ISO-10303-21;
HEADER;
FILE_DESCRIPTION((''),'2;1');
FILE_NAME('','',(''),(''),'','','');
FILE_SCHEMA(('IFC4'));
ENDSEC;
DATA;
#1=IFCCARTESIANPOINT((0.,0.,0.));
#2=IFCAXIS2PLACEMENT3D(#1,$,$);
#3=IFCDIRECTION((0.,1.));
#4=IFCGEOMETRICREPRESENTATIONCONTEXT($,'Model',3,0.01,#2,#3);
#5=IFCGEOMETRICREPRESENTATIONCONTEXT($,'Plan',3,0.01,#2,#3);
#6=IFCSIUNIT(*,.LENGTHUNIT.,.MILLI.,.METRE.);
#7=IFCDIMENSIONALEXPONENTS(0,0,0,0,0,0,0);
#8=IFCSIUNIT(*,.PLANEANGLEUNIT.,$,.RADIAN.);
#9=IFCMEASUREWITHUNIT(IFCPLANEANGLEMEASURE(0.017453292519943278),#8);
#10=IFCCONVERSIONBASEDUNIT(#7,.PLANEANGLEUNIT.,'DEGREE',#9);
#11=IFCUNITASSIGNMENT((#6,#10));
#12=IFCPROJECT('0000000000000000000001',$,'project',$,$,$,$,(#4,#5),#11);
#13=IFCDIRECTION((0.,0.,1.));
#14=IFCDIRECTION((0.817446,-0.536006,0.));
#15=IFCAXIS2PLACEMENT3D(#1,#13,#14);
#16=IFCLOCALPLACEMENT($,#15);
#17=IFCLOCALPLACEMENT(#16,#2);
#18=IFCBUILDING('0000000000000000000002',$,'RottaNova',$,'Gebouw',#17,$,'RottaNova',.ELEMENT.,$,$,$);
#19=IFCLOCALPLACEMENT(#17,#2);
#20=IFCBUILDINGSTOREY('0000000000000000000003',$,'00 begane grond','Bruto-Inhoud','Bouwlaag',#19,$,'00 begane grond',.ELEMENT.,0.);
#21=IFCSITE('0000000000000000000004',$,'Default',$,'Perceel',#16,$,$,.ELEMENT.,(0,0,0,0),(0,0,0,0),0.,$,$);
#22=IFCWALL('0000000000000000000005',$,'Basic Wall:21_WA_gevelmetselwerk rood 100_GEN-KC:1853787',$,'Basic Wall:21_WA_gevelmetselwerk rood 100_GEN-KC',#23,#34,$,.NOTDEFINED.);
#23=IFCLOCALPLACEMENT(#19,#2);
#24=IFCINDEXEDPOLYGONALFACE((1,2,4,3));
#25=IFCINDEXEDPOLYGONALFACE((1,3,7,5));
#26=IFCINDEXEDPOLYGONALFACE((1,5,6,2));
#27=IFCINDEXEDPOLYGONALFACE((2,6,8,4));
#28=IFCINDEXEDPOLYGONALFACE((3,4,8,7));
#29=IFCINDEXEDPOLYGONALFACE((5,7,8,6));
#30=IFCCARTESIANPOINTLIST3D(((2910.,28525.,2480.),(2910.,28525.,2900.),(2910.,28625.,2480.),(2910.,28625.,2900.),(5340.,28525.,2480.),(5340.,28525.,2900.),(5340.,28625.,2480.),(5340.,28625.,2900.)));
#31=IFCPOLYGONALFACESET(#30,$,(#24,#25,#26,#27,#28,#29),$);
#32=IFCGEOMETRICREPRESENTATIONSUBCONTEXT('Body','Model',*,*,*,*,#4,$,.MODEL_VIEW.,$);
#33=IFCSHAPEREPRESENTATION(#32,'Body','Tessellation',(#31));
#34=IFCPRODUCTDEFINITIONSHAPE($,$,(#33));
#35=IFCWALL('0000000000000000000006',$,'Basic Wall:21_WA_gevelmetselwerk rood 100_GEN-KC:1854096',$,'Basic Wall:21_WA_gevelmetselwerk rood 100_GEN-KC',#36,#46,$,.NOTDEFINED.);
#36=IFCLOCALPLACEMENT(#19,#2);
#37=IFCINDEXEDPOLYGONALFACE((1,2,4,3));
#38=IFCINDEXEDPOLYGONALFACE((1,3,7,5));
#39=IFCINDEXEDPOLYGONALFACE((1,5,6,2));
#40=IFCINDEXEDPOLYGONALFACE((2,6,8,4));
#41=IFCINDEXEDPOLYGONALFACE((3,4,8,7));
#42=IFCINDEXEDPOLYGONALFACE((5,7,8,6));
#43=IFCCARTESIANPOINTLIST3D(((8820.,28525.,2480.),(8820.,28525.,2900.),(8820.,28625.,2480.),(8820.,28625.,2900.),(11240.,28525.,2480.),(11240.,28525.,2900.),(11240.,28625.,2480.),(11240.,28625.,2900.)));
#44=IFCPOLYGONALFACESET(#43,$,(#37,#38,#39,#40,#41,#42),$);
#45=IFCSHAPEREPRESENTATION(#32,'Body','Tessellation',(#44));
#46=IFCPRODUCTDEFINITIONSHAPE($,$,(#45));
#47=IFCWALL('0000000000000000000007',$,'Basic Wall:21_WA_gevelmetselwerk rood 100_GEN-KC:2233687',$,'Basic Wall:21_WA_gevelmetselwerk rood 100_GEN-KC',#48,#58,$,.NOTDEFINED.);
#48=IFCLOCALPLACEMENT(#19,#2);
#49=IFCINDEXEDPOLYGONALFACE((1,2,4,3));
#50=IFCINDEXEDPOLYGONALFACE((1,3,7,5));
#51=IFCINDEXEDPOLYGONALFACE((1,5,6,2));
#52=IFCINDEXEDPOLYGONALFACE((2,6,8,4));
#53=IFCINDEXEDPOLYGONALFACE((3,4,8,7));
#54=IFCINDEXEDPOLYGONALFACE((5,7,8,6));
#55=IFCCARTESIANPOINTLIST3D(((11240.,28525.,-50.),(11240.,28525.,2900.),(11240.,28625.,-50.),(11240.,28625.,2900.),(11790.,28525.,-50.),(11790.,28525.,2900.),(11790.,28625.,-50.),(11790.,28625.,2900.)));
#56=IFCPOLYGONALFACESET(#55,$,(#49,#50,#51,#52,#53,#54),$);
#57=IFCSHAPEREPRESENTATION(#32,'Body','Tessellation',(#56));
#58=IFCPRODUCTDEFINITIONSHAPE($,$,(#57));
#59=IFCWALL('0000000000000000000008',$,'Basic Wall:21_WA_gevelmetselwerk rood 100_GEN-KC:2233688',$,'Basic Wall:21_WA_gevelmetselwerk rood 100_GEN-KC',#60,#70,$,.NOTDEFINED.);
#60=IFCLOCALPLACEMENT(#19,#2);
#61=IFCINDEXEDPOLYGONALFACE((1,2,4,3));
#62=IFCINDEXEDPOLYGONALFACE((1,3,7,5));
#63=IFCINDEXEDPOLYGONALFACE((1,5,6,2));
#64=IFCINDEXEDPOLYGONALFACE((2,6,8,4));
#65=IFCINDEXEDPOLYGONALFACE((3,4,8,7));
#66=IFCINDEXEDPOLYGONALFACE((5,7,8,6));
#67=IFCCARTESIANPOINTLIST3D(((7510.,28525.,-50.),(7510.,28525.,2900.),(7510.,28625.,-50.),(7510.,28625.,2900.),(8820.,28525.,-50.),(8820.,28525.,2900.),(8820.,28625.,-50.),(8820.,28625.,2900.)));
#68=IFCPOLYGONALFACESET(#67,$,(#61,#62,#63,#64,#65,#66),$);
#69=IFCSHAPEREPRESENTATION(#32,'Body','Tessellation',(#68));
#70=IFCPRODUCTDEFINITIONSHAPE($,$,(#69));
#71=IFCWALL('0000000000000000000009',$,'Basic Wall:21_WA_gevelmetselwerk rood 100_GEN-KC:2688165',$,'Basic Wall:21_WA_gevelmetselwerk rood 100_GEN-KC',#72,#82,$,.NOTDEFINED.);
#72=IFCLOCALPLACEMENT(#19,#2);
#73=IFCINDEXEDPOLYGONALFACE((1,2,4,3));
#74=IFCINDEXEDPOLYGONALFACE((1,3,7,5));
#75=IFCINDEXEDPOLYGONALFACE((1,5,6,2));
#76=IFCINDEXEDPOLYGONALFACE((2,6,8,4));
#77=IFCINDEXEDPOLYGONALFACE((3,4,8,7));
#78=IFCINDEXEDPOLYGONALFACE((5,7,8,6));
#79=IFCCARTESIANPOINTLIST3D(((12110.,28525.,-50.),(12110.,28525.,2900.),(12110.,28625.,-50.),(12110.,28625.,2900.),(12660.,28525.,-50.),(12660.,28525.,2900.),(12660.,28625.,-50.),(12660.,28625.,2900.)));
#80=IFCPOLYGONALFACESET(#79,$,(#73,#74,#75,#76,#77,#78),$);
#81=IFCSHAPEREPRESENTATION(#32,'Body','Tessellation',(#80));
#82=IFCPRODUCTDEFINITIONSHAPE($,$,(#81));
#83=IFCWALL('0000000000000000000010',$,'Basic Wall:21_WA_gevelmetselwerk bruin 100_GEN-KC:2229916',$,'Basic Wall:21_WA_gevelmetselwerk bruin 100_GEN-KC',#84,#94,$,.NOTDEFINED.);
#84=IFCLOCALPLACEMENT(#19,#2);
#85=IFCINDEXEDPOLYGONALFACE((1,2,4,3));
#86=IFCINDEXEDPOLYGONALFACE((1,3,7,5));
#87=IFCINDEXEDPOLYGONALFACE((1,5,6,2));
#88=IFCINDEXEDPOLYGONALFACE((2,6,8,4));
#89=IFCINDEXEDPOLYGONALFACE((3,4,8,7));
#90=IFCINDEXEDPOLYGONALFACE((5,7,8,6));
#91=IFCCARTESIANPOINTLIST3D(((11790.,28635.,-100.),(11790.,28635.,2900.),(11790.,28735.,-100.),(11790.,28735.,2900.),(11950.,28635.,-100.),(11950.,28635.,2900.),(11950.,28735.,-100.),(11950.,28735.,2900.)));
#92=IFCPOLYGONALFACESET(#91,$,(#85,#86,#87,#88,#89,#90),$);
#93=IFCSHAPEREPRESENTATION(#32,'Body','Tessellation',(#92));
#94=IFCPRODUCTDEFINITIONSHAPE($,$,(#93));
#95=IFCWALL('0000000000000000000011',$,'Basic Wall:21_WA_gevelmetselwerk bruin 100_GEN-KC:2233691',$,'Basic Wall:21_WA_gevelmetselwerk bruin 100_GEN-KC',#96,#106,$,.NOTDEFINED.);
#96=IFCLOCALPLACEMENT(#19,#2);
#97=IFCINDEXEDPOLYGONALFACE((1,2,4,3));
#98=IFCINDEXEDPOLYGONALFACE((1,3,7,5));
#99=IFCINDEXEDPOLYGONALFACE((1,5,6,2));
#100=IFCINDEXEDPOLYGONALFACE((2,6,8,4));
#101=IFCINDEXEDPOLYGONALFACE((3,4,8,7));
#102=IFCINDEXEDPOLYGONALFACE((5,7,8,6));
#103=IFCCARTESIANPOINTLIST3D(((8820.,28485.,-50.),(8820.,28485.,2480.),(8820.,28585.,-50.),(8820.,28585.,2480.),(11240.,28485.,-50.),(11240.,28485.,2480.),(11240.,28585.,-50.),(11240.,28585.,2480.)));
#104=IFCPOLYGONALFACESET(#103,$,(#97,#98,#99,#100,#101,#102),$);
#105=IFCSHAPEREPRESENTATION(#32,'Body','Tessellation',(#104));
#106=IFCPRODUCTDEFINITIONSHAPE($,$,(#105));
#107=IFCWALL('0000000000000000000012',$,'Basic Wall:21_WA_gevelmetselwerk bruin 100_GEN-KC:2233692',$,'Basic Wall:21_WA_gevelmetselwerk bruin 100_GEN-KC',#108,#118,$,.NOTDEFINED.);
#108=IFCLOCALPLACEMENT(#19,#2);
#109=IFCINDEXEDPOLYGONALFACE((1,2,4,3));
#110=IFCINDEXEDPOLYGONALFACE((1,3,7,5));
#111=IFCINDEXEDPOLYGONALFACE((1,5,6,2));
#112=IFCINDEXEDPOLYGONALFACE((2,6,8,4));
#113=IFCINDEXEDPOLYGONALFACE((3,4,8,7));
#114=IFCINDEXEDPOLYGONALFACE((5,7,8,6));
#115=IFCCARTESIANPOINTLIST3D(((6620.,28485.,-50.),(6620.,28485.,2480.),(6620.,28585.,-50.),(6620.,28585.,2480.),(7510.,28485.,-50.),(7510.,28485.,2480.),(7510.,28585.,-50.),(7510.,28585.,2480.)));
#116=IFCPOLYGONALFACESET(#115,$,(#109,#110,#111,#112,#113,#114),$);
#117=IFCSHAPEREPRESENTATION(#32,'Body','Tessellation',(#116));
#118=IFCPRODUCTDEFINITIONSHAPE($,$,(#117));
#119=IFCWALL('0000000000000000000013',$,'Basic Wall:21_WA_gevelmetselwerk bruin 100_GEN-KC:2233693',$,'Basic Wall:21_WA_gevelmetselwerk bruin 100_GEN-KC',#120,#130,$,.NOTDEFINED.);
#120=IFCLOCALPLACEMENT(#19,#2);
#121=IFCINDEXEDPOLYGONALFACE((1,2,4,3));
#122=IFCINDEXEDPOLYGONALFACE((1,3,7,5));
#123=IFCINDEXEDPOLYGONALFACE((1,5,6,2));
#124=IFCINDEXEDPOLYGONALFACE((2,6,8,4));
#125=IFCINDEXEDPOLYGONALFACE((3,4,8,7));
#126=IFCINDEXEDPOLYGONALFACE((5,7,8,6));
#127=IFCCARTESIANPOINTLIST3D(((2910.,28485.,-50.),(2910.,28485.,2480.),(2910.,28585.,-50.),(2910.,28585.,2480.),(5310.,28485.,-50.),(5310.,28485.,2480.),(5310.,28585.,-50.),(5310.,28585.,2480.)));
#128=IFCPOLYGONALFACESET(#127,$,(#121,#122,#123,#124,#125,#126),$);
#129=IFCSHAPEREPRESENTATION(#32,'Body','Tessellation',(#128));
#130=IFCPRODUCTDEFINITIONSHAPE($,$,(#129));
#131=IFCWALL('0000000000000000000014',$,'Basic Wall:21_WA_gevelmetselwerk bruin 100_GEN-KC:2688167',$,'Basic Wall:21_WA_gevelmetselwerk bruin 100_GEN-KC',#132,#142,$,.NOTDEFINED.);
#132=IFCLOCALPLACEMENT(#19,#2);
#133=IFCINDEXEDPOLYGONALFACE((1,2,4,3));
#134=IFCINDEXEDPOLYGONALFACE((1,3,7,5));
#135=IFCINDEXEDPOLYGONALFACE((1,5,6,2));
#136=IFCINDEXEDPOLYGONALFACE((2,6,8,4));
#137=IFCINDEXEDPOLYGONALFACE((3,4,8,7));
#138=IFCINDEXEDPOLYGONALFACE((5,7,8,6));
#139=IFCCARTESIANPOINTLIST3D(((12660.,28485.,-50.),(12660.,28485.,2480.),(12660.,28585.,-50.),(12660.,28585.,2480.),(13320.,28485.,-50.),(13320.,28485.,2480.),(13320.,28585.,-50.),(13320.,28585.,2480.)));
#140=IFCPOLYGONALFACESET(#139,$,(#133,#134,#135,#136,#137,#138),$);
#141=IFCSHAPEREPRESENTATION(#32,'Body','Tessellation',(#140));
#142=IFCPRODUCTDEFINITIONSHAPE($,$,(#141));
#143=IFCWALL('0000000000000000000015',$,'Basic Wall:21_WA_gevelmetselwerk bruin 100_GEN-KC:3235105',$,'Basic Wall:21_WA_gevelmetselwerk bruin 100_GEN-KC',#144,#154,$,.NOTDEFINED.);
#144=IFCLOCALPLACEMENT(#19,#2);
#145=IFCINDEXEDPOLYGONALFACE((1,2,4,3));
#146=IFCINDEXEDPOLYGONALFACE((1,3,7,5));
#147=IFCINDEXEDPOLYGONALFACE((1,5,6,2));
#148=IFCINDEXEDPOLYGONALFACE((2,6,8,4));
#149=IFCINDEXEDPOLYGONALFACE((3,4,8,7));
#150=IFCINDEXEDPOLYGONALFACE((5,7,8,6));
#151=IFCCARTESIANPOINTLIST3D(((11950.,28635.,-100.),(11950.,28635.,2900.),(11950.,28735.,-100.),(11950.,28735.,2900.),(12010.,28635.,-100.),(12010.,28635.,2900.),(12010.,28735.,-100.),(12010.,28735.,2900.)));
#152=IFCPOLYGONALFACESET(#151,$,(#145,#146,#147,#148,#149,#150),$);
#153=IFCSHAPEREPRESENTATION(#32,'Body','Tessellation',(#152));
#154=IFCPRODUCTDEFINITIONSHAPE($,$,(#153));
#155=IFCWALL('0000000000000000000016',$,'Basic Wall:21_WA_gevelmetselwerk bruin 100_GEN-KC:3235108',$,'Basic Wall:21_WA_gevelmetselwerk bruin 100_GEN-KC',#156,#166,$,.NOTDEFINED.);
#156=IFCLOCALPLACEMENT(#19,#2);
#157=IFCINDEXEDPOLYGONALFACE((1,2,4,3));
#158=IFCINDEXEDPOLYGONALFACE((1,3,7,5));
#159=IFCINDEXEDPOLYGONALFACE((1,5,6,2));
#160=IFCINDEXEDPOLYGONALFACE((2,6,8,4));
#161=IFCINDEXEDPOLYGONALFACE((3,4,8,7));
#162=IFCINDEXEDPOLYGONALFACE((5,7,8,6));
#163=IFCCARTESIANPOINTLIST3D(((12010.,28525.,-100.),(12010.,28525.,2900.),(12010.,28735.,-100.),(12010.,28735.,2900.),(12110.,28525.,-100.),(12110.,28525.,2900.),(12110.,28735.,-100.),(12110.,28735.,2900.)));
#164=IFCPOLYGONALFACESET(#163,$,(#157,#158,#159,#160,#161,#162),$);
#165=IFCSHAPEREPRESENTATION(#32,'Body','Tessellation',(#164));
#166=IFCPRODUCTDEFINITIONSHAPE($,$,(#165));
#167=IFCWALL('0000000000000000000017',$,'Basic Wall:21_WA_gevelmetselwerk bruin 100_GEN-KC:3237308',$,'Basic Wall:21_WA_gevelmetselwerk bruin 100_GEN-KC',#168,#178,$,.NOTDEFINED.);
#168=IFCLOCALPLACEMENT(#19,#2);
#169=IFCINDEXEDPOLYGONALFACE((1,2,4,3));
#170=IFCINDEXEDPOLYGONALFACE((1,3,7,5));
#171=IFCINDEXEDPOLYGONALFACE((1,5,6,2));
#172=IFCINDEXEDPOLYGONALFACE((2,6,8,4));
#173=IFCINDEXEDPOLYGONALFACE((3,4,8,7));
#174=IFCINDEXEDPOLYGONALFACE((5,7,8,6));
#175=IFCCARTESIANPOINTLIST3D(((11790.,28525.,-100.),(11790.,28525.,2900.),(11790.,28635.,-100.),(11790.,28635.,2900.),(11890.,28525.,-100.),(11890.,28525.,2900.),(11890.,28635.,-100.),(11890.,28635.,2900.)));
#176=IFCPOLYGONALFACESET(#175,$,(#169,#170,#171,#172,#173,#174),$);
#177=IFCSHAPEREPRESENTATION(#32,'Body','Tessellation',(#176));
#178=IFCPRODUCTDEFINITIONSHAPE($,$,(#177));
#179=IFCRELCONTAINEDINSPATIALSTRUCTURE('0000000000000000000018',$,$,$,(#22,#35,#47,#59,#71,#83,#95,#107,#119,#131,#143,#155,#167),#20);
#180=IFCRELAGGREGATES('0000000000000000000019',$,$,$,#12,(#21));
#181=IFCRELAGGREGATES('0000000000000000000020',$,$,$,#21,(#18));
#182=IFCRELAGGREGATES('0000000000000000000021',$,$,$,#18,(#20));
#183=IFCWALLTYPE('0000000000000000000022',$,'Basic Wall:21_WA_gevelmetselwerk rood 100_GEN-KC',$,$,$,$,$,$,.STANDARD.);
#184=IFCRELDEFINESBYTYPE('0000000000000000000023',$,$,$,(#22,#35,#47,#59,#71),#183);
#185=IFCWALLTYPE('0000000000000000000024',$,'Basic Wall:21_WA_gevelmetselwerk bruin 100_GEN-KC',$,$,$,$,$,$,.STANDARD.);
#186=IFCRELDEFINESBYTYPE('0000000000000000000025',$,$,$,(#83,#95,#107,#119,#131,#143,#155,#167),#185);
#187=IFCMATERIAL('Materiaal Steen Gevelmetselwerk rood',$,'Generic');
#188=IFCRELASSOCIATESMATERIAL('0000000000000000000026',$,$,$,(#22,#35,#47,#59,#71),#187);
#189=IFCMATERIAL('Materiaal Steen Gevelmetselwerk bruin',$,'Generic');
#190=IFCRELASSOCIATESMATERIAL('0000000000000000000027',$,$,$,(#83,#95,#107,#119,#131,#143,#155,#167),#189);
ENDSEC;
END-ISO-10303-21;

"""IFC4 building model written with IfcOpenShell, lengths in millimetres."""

from ifc_helpers import new_model, entity, si_unit, converted_unit, direction, frame, origin, place, context, subcontext, project, spatial, indexed_curve, outline, extrude, material, type_object, element, save


model = new_model("IFC4")

# Units and contexts
model_context = context("Model", 3, precision=0.01, world=origin(), true_north=direction((0.0, 1.0)))
plan_context = context("Plan", 3, precision=0.01, world=origin(), true_north=direction((0.0, 1.0)))
body_context = subcontext(model_context, "Body", "Model", "MODEL_VIEW")
ifc_project = project(units=[si_unit("LENGTHUNIT", "METRE", prefix="MILLI"), converted_unit("PLANEANGLEUNIT", "DEGREE", entity("IfcPlaneAngleMeasure", 0.017453292519943278), si_unit("PLANEANGLEUNIT", "RADIAN"), dimensions=[0, 0, 0, 0, 0, 0, 0])], contexts=[model_context, plan_context])

# Site, building, storey
site_placement = place(None, frame((0.0, 0.0, 0.0), z_axis=(0.0, 0.0, 1.0), x_axis=(0.817446, -0.536006, 0.0)))
site = spatial("IfcSite", under=ifc_project, at=site_placement, Name="Default", ObjectType="Perceel", CompositionType="ELEMENT", RefLatitude=(0, 0, 0, 0), RefLongitude=(0, 0, 0, 0), RefElevation=0.0)
building_placement = place(site_placement, origin())
building = spatial("IfcBuilding", under=site, at=building_placement, Name="RottaNova", ObjectType="Gebouw", LongName="RottaNova", CompositionType="ELEMENT")
storey_placement = place(building_placement, origin())
storey = spatial("IfcBuildingStorey", under=building, at=storey_placement, Name="00 begane grond", Description="Bruto-Inhoud", ObjectType="Bouwlaag", LongName="00 begane grond", CompositionType="ELEMENT", Elevation=0.0)

# Walls
ifc_material_1 = material(Name="Materiaal Steen Gevelmetselwerk rood", Category="Generic")
wall_type_1 = type_object("IfcWallType", Name="Basic Wall:21_WA_gevelmetselwerk rood 100_GEN-KC", PredefinedType="STANDARD")
wall_1_placement = place(storey_placement, frame((2910.0, 28575.0, 2480.0)))
element("IfcWall", 1, at=wall_1_placement, inside=storey, type_object=wall_type_1, material=ifc_material_1, Name="Basic Wall:21_WA_gevelmetselwerk rood 100_GEN-KC:1853787", ObjectType="Basic Wall:21_WA_gevelmetselwerk rood 100_GEN-KC", PredefinedType="NOTDEFINED", context=body_context, shape_type="SweptSolid", body=[
    extrude(outline(indexed_curve([(2430.0, 50.0), (0.0, 50.0), (0.0, -50.0), (2430.0, -50.0), (2430.0, 50.0)], self_intersect=False)), origin(), (0.0, 0.0, 1.0), 420.0),
])
wall_2_placement = place(storey_placement, frame((8820.0, 28575.0, 2480.0)))
element("IfcWall", 2, at=wall_2_placement, inside=storey, type_object=wall_type_1, material=ifc_material_1, Name="Basic Wall:21_WA_gevelmetselwerk rood 100_GEN-KC:1854096", ObjectType="Basic Wall:21_WA_gevelmetselwerk rood 100_GEN-KC", PredefinedType="NOTDEFINED", context=body_context, shape_type="SweptSolid", body=[
    extrude(outline(indexed_curve([(2420.0, 50.0), (0.0, 50.0), (0.0, -50.0), (2420.0, -50.0), (2420.0, 50.0)], self_intersect=False)), origin(), (0.0, 0.0, 1.0), 420.0),
])
wall_3_placement = place(storey_placement, frame((11240.0, 28575.0, -50.0)))
element("IfcWall", 3, at=wall_3_placement, inside=storey, type_object=wall_type_1, material=ifc_material_1, Name="Basic Wall:21_WA_gevelmetselwerk rood 100_GEN-KC:2233687", ObjectType="Basic Wall:21_WA_gevelmetselwerk rood 100_GEN-KC", PredefinedType="NOTDEFINED", context=body_context, shape_type="SweptSolid", body=[
    extrude(outline(indexed_curve([(550.0, 50.0), (0.0, 50.0), (0.0, -50.0), (550.0, -50.0), (550.0, 50.0)], self_intersect=False)), origin(), (0.0, 0.0, 1.0), 2950.0),
])
wall_4_placement = place(storey_placement, frame((7510.0, 28575.0, -50.0)))
element("IfcWall", 4, at=wall_4_placement, inside=storey, type_object=wall_type_1, material=ifc_material_1, Name="Basic Wall:21_WA_gevelmetselwerk rood 100_GEN-KC:2233688", ObjectType="Basic Wall:21_WA_gevelmetselwerk rood 100_GEN-KC", PredefinedType="NOTDEFINED", context=body_context, shape_type="SweptSolid", body=[
    extrude(outline(indexed_curve([(1310.0, 50.0), (0.0, 50.0), (0.0, -50.0), (1310.0, -50.0), (1310.0, 50.0)], self_intersect=False)), origin(), (0.0, 0.0, 1.0), 2950.0),
])
wall_5_placement = place(storey_placement, frame((12660.0, 28575.0, -50.0), z_axis=(0.0, 0.0, 1.0), x_axis=(-1.0, 0.0, 0.0)))
element("IfcWall", 5, at=wall_5_placement, inside=storey, type_object=wall_type_1, material=ifc_material_1, Name="Basic Wall:21_WA_gevelmetselwerk rood 100_GEN-KC:2688165", ObjectType="Basic Wall:21_WA_gevelmetselwerk rood 100_GEN-KC", PredefinedType="NOTDEFINED", context=body_context, shape_type="SweptSolid", body=[
    extrude(outline(indexed_curve([(550.0, 50.0), (0.0, 50.0), (0.0, -50.0), (550.0, -50.0), (550.0, 50.0)], self_intersect=False)), origin(), (0.0, 0.0, 1.0), 2950.0),
])
ifc_material_2 = material(Name="Materiaal Steen Gevelmetselwerk bruin", Category="Generic")
wall_type_2 = type_object("IfcWallType", Name="Basic Wall:21_WA_gevelmetselwerk bruin 100_GEN-KC", PredefinedType="STANDARD")
wall_6_placement = place(storey_placement, frame((11790.0, 28685.0, -100.0)))
element("IfcWall", 6, at=wall_6_placement, inside=storey, type_object=wall_type_2, material=ifc_material_2, Name="Basic Wall:21_WA_gevelmetselwerk bruin 100_GEN-KC:2229916", ObjectType="Basic Wall:21_WA_gevelmetselwerk bruin 100_GEN-KC", PredefinedType="NOTDEFINED", context=body_context, shape_type="SweptSolid", body=[
    extrude(outline(indexed_curve([(160.0, 50.0), (0.0, 50.0), (0.0, -50.0), (160.0, -50.0), (160.0, 50.0)], self_intersect=False)), origin(), (0.0, 0.0, 1.0), 3000.0),
])
wall_7_placement = place(storey_placement, frame((11240.0, 28535.0, -50.0), z_axis=(0.0, 0.0, 1.0), x_axis=(-1.0, 0.0, 0.0)))
element("IfcWall", 7, at=wall_7_placement, inside=storey, type_object=wall_type_2, material=ifc_material_2, Name="Basic Wall:21_WA_gevelmetselwerk bruin 100_GEN-KC:2233691", ObjectType="Basic Wall:21_WA_gevelmetselwerk bruin 100_GEN-KC", PredefinedType="NOTDEFINED", context=body_context, shape_type="SweptSolid", body=[
    extrude(outline(indexed_curve([(2420.0, 50.0), (0.0, 50.0), (0.0, -50.0), (2420.0, -50.0), (2420.0, 50.0)], self_intersect=False)), origin(), (0.0, 0.0, 1.0), 2530.0),
])
wall_8_placement = place(storey_placement, frame((7510.0, 28535.0, -50.0), z_axis=(0.0, 0.0, 1.0), x_axis=(-1.0, 0.0, 0.0)))
element("IfcWall", 8, at=wall_8_placement, inside=storey, type_object=wall_type_2, material=ifc_material_2, Name="Basic Wall:21_WA_gevelmetselwerk bruin 100_GEN-KC:2233692", ObjectType="Basic Wall:21_WA_gevelmetselwerk bruin 100_GEN-KC", PredefinedType="NOTDEFINED", context=body_context, shape_type="SweptSolid", body=[
    extrude(outline(indexed_curve([(890.0, 50.0), (0.0, 50.0), (0.0, -50.0), (890.0, -50.0), (890.0, 50.0)], self_intersect=False)), origin(), (0.0, 0.0, 1.0), 2530.0),
])
wall_9_placement = place(storey_placement, frame((5310.0, 28535.0, -50.0), z_axis=(0.0, 0.0, 1.0), x_axis=(-1.0, 0.0, 0.0)))
element("IfcWall", 9, at=wall_9_placement, inside=storey, type_object=wall_type_2, material=ifc_material_2, Name="Basic Wall:21_WA_gevelmetselwerk bruin 100_GEN-KC:2233693", ObjectType="Basic Wall:21_WA_gevelmetselwerk bruin 100_GEN-KC", PredefinedType="NOTDEFINED", context=body_context, shape_type="SweptSolid", body=[
    extrude(outline(indexed_curve([(2400.0, 50.0), (0.0, 50.0), (0.0, -50.0), (2400.0, -50.0), (2400.0, 50.0)], self_intersect=False)), origin(), (0.0, 0.0, 1.0), 2530.0),
])
wall_10_placement = place(storey_placement, frame((12660.0, 28535.0, -50.0)))
element("IfcWall", 10, at=wall_10_placement, inside=storey, type_object=wall_type_2, material=ifc_material_2, Name="Basic Wall:21_WA_gevelmetselwerk bruin 100_GEN-KC:2688167", ObjectType="Basic Wall:21_WA_gevelmetselwerk bruin 100_GEN-KC", PredefinedType="NOTDEFINED", context=body_context, shape_type="SweptSolid", body=[
    extrude(outline(indexed_curve([(660.0, 50.0), (0.0, 50.0), (0.0, -50.0), (660.0, -50.0), (660.0, 50.0)], self_intersect=False)), origin(), (0.0, 0.0, 1.0), 2530.0),
])
wall_11_placement = place(storey_placement, frame((12010.0, 28685.0, -100.0), z_axis=(0.0, 0.0, 1.0), x_axis=(-1.0, 0.0, 0.0)))
element("IfcWall", 11, at=wall_11_placement, inside=storey, type_object=wall_type_2, material=ifc_material_2, Name="Basic Wall:21_WA_gevelmetselwerk bruin 100_GEN-KC:3235105", ObjectType="Basic Wall:21_WA_gevelmetselwerk bruin 100_GEN-KC", PredefinedType="NOTDEFINED", context=body_context, shape_type="SweptSolid", body=[
    extrude(outline(indexed_curve([(60.0, 50.0), (0.0, 50.0), (0.0, -50.0), (60.0, -50.0), (60.0, 50.0)], self_intersect=False)), origin(), (0.0, 0.0, 1.0), 3000.0),
])
wall_12_placement = place(storey_placement, frame((12060.0, 28735.0, -100.0), z_axis=(0.0, 0.0, 1.0), x_axis=(0.0, -1.0, 0.0)))
element("IfcWall", 12, at=wall_12_placement, inside=storey, type_object=wall_type_2, material=ifc_material_2, Name="Basic Wall:21_WA_gevelmetselwerk bruin 100_GEN-KC:3235108", ObjectType="Basic Wall:21_WA_gevelmetselwerk bruin 100_GEN-KC", PredefinedType="NOTDEFINED", context=body_context, shape_type="SweptSolid", body=[
    extrude(outline(indexed_curve([(210.0, 50.0), (0.0, 50.0), (0.0, -50.0), (210.0, -50.0), (210.0, 50.0)], self_intersect=False)), origin(), (0.0, 0.0, 1.0), 3000.0),
])
wall_13_placement = place(storey_placement, frame((11840.0, 28635.0, -100.0), z_axis=(0.0, 0.0, 1.0), x_axis=(0.0, -1.0, 0.0)))
element("IfcWall", 13, at=wall_13_placement, inside=storey, type_object=wall_type_2, material=ifc_material_2, Name="Basic Wall:21_WA_gevelmetselwerk bruin 100_GEN-KC:3237308", ObjectType="Basic Wall:21_WA_gevelmetselwerk bruin 100_GEN-KC", PredefinedType="NOTDEFINED", context=body_context, shape_type="SweptSolid", body=[
    extrude(outline(indexed_curve([(110.0, 50.0), (0.0, 50.0), (0.0, -50.0), (110.0, -50.0), (110.0, 50.0)], self_intersect=False)), origin(), (0.0, 0.0, 1.0), 3000.0),
])

save(model, "model.ifc")
